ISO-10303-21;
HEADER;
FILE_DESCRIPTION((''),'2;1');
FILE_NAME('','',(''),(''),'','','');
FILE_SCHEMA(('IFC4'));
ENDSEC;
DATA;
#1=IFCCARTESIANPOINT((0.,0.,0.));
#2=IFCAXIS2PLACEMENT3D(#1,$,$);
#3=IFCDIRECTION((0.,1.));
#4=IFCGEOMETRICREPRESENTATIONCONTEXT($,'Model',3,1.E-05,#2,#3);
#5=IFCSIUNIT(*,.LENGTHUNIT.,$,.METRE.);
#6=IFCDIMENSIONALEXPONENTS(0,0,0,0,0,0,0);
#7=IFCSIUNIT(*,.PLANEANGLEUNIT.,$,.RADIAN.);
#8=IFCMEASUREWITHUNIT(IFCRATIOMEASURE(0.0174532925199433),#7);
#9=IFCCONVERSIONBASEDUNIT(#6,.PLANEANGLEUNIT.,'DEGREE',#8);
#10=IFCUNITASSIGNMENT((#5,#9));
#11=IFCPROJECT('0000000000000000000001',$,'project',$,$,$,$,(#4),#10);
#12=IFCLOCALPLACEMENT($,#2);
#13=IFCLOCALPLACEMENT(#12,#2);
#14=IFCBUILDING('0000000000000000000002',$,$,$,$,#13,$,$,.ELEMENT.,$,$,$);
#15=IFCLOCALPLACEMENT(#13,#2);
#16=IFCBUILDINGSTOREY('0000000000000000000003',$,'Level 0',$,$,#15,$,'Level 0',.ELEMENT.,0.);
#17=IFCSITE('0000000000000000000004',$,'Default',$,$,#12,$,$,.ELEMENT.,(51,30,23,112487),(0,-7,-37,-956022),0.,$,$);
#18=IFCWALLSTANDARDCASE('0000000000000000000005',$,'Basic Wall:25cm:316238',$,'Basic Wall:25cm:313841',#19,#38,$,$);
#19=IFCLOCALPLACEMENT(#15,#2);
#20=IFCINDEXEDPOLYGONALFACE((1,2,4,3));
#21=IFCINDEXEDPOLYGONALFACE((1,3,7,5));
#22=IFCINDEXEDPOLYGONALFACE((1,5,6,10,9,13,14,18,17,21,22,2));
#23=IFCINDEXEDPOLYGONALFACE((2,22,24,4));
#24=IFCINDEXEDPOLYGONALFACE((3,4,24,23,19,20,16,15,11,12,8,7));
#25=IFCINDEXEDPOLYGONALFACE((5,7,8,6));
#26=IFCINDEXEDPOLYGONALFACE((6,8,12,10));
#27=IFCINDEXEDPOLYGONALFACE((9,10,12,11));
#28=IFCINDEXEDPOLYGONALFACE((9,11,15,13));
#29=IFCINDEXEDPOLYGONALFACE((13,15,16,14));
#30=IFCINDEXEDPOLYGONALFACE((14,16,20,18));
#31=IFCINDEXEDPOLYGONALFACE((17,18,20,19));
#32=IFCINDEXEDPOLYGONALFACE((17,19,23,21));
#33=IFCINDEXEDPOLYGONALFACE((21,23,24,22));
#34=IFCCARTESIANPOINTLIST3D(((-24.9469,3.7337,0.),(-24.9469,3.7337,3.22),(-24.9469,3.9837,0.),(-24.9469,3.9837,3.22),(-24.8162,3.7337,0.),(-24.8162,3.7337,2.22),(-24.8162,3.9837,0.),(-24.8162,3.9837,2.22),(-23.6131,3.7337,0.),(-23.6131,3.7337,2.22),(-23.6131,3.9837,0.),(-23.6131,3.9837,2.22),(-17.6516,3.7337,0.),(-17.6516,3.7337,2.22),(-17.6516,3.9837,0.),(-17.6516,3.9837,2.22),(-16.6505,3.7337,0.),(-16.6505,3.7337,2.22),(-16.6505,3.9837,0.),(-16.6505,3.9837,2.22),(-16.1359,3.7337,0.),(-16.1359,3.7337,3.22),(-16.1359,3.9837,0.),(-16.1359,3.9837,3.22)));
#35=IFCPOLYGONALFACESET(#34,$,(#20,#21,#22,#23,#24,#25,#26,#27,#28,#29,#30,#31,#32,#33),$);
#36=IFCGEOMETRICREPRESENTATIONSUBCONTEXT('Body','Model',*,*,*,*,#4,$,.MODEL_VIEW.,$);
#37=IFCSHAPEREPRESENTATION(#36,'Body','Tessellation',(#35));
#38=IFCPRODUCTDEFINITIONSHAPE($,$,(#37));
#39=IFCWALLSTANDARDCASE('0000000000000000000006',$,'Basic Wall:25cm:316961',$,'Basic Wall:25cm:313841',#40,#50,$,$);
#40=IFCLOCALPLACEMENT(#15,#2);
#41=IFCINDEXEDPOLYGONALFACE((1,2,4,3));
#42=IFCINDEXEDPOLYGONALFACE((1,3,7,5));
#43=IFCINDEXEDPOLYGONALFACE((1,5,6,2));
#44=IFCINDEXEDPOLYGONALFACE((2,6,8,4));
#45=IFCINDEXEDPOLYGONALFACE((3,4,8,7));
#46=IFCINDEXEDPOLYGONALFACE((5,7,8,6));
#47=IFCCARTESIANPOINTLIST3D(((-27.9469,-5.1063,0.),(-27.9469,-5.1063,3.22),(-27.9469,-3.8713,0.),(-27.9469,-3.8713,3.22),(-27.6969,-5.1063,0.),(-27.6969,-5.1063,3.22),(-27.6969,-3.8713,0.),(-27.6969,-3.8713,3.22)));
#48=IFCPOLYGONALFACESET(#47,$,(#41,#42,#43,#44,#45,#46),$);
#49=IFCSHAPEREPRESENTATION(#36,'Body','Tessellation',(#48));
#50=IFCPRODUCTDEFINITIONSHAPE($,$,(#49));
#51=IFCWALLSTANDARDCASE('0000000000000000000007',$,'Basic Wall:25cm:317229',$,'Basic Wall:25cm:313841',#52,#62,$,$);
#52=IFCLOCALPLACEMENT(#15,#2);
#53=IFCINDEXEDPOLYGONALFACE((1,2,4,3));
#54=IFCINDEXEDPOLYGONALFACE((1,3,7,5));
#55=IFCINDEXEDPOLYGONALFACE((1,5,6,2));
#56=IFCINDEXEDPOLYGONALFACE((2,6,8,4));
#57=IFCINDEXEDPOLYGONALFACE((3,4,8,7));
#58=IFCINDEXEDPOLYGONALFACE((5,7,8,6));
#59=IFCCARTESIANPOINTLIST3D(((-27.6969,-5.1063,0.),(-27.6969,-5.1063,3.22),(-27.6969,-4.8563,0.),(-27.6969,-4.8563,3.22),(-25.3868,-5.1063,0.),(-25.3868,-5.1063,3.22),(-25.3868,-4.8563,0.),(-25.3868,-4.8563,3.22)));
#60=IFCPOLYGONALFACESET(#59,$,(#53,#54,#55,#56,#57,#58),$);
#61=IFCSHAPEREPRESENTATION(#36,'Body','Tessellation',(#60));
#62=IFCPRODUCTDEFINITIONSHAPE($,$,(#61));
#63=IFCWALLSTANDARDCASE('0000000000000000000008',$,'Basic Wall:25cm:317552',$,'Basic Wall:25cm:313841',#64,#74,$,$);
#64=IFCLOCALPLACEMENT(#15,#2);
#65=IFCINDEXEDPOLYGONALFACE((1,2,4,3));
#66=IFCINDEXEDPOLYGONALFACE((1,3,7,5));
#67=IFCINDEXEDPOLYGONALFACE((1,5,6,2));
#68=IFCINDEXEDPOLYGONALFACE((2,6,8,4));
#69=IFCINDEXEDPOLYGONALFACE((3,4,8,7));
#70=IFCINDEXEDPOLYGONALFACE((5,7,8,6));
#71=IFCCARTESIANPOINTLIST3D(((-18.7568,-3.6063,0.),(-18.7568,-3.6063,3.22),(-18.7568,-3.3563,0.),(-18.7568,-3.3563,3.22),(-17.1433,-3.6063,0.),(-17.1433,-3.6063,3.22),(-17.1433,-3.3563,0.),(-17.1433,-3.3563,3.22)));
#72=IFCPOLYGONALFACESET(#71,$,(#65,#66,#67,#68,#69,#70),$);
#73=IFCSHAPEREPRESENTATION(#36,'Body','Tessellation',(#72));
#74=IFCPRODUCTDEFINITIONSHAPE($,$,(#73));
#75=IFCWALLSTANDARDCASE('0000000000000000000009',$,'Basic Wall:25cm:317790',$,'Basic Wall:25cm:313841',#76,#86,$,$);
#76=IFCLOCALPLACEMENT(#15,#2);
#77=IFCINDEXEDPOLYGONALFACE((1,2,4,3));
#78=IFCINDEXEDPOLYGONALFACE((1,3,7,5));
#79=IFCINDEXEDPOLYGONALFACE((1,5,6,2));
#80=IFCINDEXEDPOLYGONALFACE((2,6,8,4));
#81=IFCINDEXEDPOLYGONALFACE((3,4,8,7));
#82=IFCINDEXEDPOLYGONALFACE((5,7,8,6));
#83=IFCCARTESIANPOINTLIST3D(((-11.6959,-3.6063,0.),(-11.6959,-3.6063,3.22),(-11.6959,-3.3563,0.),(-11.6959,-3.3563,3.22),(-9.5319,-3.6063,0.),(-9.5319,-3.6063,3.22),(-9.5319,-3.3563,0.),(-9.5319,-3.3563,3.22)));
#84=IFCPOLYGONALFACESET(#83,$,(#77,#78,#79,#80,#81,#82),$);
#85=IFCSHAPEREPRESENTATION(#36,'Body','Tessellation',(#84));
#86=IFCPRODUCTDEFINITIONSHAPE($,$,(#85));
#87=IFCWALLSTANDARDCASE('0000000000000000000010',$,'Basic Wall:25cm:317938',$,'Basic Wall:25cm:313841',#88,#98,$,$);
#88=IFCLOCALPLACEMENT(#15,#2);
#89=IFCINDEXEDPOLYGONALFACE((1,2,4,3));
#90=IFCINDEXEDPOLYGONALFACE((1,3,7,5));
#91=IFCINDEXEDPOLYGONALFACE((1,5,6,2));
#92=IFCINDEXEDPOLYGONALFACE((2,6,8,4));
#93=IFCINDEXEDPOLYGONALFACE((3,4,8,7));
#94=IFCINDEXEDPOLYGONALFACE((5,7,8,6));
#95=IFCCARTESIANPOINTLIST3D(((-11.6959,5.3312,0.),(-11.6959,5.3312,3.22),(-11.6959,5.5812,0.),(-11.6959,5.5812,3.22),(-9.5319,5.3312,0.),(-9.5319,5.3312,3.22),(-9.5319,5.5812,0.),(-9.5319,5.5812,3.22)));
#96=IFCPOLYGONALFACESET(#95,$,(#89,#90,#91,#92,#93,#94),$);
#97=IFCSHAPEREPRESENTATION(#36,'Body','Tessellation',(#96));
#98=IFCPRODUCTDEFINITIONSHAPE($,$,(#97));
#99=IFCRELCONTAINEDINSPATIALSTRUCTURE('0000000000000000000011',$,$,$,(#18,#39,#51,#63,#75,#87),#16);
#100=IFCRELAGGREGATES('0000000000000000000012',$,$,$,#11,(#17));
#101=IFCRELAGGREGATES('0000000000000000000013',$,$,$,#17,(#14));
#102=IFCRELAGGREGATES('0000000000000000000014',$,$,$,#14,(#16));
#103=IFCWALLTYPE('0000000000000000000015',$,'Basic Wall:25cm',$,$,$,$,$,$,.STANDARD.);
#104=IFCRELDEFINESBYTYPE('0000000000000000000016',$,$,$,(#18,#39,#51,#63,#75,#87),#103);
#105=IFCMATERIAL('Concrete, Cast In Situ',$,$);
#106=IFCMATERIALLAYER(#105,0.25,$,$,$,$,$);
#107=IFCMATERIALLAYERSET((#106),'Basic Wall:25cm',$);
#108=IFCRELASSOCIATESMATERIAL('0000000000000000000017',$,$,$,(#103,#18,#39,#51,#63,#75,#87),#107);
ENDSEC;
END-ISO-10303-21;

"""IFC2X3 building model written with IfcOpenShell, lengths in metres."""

from ifc_helpers import new_model, entity, si_unit, converted_unit, direction, frame, frame_2d, origin, origin_2d_with_axis, place, context, subcontext, project, spatial, rectangle, extrude, material, layer, layer_set, layer_usage, type_object, element, save


model = new_model("IFC2X3")

# Units and contexts
model_context = context("Model", 3, precision=1e-05, world=origin(), true_north=direction((0.0, 1.0)))
body_context = subcontext(model_context, "Body", "Model", "MODEL_VIEW")
ifc_project = project(units=[si_unit("LENGTHUNIT", "METRE"), converted_unit("PLANEANGLEUNIT", "DEGREE", entity("IfcRatioMeasure", 0.0174532925199433), si_unit("PLANEANGLEUNIT", "RADIAN"), dimensions=[0, 0, 0, 0, 0, 0, 0])], contexts=[model_context])

# Site, building, storey
site_placement = place(None, origin())
site = spatial("IfcSite", under=ifc_project, at=site_placement, Name="Default", CompositionType="ELEMENT", RefLatitude=(51, 30, 23, 112487), RefLongitude=(0, -7, -37, -956022), RefElevation=0.0)
building_placement = place(site_placement, origin())
building = spatial("IfcBuilding", under=site, at=building_placement, CompositionType="ELEMENT")
storey_placement = place(building_placement, origin())
storey = spatial("IfcBuildingStorey", under=building, at=storey_placement, Name="Level 0", LongName="Level 0", CompositionType="ELEMENT", Elevation=0.0)

# Shared definitions
ifc_material_1 = material(Name="Concrete, Cast In Situ")
ifc_layer = layer(ifc_material_1, 0.25)
ifc_layer_set = layer_set([ifc_layer], Name="Basic Wall:25cm")
wall_type = type_object("IfcWallType", Name="Basic Wall:25cm", PredefinedType="STANDARD", material=ifc_layer_set)

# Wall, openings
ifc_layer_usage_1 = layer_usage(ifc_layer_set, "AXIS2", "POSITIVE", -0.125)
wall_1_placement = place(storey_placement, frame((-16.1359, 3.8587, 0.0), z_axis=(0.0, 0.0, 1.0), x_axis=(-1.0, -0.000001, 0.0)))
wall_1 = element("IfcWallStandardCase", 1, at=wall_1_placement, inside=storey, type_object=wall_type, material=ifc_layer_usage_1, Name="Basic Wall:25cm:316238", ObjectType="Basic Wall:25cm:313841", context=body_context, shape_type="SweptSolid", body=[
    extrude(rectangle(XDim=8.811, YDim=0.25, at=frame_2d((4.4055, 0.0), x_axis=(-1.0, 0.0))), origin(), (0.0, 0.0, 1.0), 3.22),
])
opening_1_placement = place(wall_1_placement, origin())
element("IfcOpeningElement", 2, at=opening_1_placement, cuts=wall_1, ObjectType="Opening", context=body_context, shape_type="SweptSolid", body=[
    extrude(rectangle(XDim=2.22, YDim=1.2031, at=origin_2d_with_axis()), frame((8.0788, -0.125, 1.11), z_axis=(0.0, 1.0, 0.0), x_axis=(0.0, 0.0, -1.0)), (0.0, 0.0, 1.0), 0.25),
])
opening_2_placement = place(wall_1_placement, origin())
element("IfcOpeningElement", 3, at=opening_2_placement, cuts=wall_1, ObjectType="Opening", context=body_context, shape_type="SweptSolid", body=[
    extrude(rectangle(XDim=2.22, YDim=1.0011, at=frame_2d((0.0, 0.0), x_axis=(1.0, 0.0))), frame((1.0152, -0.125, 1.11), z_axis=(0.0, 1.0, 0.0), x_axis=(0.0, 0.0, -1.0)), (0.0, 0.0, 1.0), 0.25),
])

# Walls
ifc_layer_usage_2 = layer_usage(ifc_layer_set, "AXIS2", "NEGATIVE", 0.125)
wall_2_placement = place(storey_placement, frame((-27.8219, -3.8713, 0.0), z_axis=(0.0, 0.0, 1.0), x_axis=(0.0, -1.0, 0.0)))
element("IfcWallStandardCase", 4, at=wall_2_placement, inside=storey, type_object=wall_type, material=ifc_layer_usage_2, Name="Basic Wall:25cm:316961", ObjectType="Basic Wall:25cm:313841", context=body_context, shape_type="SweptSolid", body=[
    extrude(rectangle(XDim=1.235, YDim=0.25, at=frame_2d((0.6175, 0.0), x_axis=(-1.0, 0.0))), origin(), (0.0, 0.0, 1.0), 3.22),
])
ifc_layer_usage_3 = layer_usage(ifc_layer_set, "AXIS2", "NEGATIVE", 0.125)
wall_3_placement = place(storey_placement, frame((-27.6969, -4.9813, 0.0)))
element("IfcWallStandardCase", 5, at=wall_3_placement, inside=storey, type_object=wall_type, material=ifc_layer_usage_3, Name="Basic Wall:25cm:317229", ObjectType="Basic Wall:25cm:313841", context=body_context, shape_type="SweptSolid", body=[
    extrude(rectangle(XDim=2.31, YDim=0.25, at=frame_2d((1.155, 0.0), x_axis=(-1.0, 0.0))), origin(), (0.0, 0.0, 1.0), 3.22),
])
ifc_layer_usage_4 = layer_usage(ifc_layer_set, "AXIS2", "NEGATIVE", 0.125)
wall_4_placement = place(storey_placement, frame((-18.7568, -3.4813, 0.0)))
element("IfcWallStandardCase", 6, at=wall_4_placement, inside=storey, type_object=wall_type, material=ifc_layer_usage_4, Name="Basic Wall:25cm:317552", ObjectType="Basic Wall:25cm:313841", context=body_context, shape_type="SweptSolid", body=[
    extrude(rectangle(XDim=1.6135, YDim=0.25, at=frame_2d((0.8068, 0.0), x_axis=(-1.0, 0.0))), origin(), (0.0, 0.0, 1.0), 3.22),
])
ifc_layer_usage_5 = layer_usage(ifc_layer_set, "AXIS2", "NEGATIVE", 0.125)
wall_5_placement = place(storey_placement, frame((-11.6959, -3.4813, 0.0)))
element("IfcWallStandardCase", 7, at=wall_5_placement, inside=storey, type_object=wall_type, material=ifc_layer_usage_5, Name="Basic Wall:25cm:317790", ObjectType="Basic Wall:25cm:313841", context=body_context, shape_type="SweptSolid", body=[
    extrude(rectangle(XDim=2.164, YDim=0.25, at=frame_2d((1.082, 0.0), x_axis=(-1.0, 0.0))), origin(), (0.0, 0.0, 1.0), 3.22),
])
ifc_layer_usage_6 = layer_usage(ifc_layer_set, "AXIS2", "NEGATIVE", 0.125)
wall_6_placement = place(storey_placement, frame((-11.6959, 5.4562, 0.0)))
element("IfcWallStandardCase", 8, at=wall_6_placement, inside=storey, type_object=wall_type, material=ifc_layer_usage_6, Name="Basic Wall:25cm:317938", ObjectType="Basic Wall:25cm:313841", context=body_context, shape_type="SweptSolid", body=[
    extrude(rectangle(XDim=2.164, YDim=0.25, at=frame_2d((1.082, 0.0), x_axis=(-1.0, 0.0))), origin(), (0.0, 0.0, 1.0), 3.22),
])

save(model, "model.ifc")
